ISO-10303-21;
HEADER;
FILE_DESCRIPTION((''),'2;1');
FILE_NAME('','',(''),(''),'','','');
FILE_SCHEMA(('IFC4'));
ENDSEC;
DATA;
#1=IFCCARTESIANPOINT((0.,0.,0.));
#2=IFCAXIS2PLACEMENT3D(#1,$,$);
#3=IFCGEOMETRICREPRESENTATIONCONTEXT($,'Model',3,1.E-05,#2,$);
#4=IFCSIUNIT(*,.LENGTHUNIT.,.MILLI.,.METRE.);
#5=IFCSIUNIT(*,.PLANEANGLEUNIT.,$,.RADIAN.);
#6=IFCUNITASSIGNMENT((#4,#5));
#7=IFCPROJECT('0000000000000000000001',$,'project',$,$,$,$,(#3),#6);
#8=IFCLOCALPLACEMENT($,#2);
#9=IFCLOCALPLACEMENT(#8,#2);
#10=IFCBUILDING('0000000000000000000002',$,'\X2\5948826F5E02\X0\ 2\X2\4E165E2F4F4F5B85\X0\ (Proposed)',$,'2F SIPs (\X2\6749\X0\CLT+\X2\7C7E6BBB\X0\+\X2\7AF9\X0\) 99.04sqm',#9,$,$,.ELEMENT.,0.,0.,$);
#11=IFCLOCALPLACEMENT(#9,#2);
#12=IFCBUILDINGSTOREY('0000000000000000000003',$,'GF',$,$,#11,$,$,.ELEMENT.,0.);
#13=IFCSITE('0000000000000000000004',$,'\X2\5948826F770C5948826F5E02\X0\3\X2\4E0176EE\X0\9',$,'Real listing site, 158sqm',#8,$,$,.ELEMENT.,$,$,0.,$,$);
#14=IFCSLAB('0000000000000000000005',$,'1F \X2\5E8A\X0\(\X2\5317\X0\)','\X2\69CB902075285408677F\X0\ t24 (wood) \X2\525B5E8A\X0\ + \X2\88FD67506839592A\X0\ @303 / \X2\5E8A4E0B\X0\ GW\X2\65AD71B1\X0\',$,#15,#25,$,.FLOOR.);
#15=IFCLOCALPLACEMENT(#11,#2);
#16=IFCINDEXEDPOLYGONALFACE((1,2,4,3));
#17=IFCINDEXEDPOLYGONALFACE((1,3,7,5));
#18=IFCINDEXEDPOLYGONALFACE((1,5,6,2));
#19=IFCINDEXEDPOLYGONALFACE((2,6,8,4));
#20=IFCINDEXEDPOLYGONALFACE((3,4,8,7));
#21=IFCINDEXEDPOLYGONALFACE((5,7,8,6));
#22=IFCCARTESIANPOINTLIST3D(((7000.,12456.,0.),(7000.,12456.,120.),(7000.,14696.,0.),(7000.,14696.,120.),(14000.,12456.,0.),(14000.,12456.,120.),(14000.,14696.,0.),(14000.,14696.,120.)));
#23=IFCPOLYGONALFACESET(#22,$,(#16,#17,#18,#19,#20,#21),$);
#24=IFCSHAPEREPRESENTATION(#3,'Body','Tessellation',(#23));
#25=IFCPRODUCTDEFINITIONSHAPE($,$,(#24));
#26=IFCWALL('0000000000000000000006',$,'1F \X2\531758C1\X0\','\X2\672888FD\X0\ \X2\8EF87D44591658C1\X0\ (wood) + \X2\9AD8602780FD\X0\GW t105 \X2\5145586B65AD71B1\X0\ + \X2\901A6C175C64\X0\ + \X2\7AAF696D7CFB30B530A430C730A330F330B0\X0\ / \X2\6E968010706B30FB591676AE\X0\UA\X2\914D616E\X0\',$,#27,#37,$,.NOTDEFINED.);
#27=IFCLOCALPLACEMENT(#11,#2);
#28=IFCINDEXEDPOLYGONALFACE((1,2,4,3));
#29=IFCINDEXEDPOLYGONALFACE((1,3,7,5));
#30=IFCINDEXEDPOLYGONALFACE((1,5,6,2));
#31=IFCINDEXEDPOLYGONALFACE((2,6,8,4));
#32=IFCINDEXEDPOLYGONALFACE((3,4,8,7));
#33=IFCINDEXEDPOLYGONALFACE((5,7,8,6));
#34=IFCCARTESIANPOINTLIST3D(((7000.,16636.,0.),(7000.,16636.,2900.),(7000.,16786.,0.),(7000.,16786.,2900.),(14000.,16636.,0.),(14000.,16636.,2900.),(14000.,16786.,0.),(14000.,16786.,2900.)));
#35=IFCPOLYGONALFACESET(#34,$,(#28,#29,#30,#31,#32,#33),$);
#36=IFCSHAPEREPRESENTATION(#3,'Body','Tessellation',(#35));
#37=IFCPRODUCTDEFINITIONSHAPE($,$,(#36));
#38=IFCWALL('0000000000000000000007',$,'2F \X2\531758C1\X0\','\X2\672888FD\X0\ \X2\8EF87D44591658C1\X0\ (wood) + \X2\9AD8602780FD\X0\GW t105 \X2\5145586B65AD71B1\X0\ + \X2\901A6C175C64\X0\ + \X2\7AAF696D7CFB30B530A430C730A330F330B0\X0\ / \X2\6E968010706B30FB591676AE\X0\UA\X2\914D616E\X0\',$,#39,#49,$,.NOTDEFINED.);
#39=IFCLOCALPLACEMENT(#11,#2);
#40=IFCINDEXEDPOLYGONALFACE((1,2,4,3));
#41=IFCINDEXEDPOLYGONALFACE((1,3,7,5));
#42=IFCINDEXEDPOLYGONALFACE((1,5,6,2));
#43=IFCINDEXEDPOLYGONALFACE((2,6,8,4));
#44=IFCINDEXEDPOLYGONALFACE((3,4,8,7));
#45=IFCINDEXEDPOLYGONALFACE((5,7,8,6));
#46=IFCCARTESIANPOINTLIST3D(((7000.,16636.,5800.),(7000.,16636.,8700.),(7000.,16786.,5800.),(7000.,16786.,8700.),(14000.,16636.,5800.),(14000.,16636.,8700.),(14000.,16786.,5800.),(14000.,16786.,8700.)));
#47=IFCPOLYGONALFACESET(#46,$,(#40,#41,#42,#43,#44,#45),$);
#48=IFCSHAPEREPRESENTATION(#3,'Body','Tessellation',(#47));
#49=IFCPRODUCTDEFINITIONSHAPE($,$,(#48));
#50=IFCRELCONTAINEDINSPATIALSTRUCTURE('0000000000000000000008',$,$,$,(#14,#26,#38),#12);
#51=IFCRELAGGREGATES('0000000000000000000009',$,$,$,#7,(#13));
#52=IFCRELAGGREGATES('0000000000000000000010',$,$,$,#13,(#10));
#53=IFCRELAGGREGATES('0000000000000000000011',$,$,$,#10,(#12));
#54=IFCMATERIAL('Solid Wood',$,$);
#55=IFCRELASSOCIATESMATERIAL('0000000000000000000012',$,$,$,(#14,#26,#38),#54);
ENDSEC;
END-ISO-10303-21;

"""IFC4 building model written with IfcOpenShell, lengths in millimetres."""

from ifc_helpers import new_model, si_unit, frame, frame_2d, origin, place, context, project, spatial, rectangle, extrude, material, element, save


model = new_model("IFC4")

# Units and contexts
model_context = context("Model", 3, precision=1e-05, world=origin())
ifc_project = project(units=[si_unit("LENGTHUNIT", "METRE", prefix="MILLI"), si_unit("PLANEANGLEUNIT", "RADIAN")], contexts=[model_context])

# Site, building, storey
site_placement = place(None, origin())
site = spatial("IfcSite", under=ifc_project, at=site_placement, Name="奈良県奈良市3丁目9", ObjectType="Real listing site, 158sqm", CompositionType="ELEMENT", RefElevation=0.0)
building_placement = place(site_placement, origin())
building = spatial("IfcBuilding", under=site, at=building_placement, Name="奈良市 2世帯住宅 (Proposed)", ObjectType="2F SIPs (杉CLT+籾殻+竹) 99.04sqm", CompositionType="ELEMENT", ElevationOfRefHeight=0.0, ElevationOfTerrain=0.0)
storey_placement = place(building_placement, origin())
storey = spatial("IfcBuildingStorey", under=building, at=storey_placement, Name="GF", CompositionType="ELEMENT", Elevation=0.0)

# Slab
ifc_material_1 = material(Name="Solid Wood")
slab_1_placement = place(storey_placement, frame((3500.0, 6228.0, 0.0)))
element("IfcSlab", 1, at=slab_1_placement, inside=storey, material=ifc_material_1, Name="1F 床(北)", Description="構造用合板 t24 (wood) 剛床 + 製材根太 @303 / 床下 GW断熱", PredefinedType="FLOOR", context=model_context, shape_type="SweptSolid", body=[
    extrude(rectangle(XDim=7000.0, YDim=2240.0, at=frame_2d((3500.0, 1120.0))), frame((3500.0, 6228.0, 0.0)), (0.0, 0.0, 1.0), 120.0),
])

# Wall
wall_1_placement = place(storey_placement, frame((3500.0, 8318.0, 0.0)))
element("IfcWall", 2, at=wall_1_placement, inside=storey, material=ifc_material_1, Name="1F 北壁", Description="木製 軸組外壁 (wood) + 高性能GW t105 充填断熱 + 通気層 + 窯業系サイディング / 準耐火・外皮UA配慮", PredefinedType="NOTDEFINED", context=model_context, shape_type="SweptSolid", body=[
    extrude(rectangle(XDim=7000.0, YDim=150.0, at=frame_2d((3500.0, 75.0))), frame((3500.0, 8318.0, 0.0)), (0.0, 0.0, 1.0), 2900.0),
])

# Wall
wall_2_placement = place(storey_placement, frame((3500.0, 8318.0, 2900.0)))
element("IfcWall", 3, at=wall_2_placement, inside=storey, material=ifc_material_1, Name="2F 北壁", Description="木製 軸組外壁 (wood) + 高性能GW t105 充填断熱 + 通気層 + 窯業系サイディング / 準耐火・外皮UA配慮", PredefinedType="NOTDEFINED", context=model_context, shape_type="SweptSolid", body=[
    extrude(rectangle(XDim=7000.0, YDim=150.0, at=frame_2d((3500.0, 75.0))), frame((3500.0, 8318.0, 2900.0)), (0.0, 0.0, 1.0), 2900.0),
])

save(model, "model.ifc")
